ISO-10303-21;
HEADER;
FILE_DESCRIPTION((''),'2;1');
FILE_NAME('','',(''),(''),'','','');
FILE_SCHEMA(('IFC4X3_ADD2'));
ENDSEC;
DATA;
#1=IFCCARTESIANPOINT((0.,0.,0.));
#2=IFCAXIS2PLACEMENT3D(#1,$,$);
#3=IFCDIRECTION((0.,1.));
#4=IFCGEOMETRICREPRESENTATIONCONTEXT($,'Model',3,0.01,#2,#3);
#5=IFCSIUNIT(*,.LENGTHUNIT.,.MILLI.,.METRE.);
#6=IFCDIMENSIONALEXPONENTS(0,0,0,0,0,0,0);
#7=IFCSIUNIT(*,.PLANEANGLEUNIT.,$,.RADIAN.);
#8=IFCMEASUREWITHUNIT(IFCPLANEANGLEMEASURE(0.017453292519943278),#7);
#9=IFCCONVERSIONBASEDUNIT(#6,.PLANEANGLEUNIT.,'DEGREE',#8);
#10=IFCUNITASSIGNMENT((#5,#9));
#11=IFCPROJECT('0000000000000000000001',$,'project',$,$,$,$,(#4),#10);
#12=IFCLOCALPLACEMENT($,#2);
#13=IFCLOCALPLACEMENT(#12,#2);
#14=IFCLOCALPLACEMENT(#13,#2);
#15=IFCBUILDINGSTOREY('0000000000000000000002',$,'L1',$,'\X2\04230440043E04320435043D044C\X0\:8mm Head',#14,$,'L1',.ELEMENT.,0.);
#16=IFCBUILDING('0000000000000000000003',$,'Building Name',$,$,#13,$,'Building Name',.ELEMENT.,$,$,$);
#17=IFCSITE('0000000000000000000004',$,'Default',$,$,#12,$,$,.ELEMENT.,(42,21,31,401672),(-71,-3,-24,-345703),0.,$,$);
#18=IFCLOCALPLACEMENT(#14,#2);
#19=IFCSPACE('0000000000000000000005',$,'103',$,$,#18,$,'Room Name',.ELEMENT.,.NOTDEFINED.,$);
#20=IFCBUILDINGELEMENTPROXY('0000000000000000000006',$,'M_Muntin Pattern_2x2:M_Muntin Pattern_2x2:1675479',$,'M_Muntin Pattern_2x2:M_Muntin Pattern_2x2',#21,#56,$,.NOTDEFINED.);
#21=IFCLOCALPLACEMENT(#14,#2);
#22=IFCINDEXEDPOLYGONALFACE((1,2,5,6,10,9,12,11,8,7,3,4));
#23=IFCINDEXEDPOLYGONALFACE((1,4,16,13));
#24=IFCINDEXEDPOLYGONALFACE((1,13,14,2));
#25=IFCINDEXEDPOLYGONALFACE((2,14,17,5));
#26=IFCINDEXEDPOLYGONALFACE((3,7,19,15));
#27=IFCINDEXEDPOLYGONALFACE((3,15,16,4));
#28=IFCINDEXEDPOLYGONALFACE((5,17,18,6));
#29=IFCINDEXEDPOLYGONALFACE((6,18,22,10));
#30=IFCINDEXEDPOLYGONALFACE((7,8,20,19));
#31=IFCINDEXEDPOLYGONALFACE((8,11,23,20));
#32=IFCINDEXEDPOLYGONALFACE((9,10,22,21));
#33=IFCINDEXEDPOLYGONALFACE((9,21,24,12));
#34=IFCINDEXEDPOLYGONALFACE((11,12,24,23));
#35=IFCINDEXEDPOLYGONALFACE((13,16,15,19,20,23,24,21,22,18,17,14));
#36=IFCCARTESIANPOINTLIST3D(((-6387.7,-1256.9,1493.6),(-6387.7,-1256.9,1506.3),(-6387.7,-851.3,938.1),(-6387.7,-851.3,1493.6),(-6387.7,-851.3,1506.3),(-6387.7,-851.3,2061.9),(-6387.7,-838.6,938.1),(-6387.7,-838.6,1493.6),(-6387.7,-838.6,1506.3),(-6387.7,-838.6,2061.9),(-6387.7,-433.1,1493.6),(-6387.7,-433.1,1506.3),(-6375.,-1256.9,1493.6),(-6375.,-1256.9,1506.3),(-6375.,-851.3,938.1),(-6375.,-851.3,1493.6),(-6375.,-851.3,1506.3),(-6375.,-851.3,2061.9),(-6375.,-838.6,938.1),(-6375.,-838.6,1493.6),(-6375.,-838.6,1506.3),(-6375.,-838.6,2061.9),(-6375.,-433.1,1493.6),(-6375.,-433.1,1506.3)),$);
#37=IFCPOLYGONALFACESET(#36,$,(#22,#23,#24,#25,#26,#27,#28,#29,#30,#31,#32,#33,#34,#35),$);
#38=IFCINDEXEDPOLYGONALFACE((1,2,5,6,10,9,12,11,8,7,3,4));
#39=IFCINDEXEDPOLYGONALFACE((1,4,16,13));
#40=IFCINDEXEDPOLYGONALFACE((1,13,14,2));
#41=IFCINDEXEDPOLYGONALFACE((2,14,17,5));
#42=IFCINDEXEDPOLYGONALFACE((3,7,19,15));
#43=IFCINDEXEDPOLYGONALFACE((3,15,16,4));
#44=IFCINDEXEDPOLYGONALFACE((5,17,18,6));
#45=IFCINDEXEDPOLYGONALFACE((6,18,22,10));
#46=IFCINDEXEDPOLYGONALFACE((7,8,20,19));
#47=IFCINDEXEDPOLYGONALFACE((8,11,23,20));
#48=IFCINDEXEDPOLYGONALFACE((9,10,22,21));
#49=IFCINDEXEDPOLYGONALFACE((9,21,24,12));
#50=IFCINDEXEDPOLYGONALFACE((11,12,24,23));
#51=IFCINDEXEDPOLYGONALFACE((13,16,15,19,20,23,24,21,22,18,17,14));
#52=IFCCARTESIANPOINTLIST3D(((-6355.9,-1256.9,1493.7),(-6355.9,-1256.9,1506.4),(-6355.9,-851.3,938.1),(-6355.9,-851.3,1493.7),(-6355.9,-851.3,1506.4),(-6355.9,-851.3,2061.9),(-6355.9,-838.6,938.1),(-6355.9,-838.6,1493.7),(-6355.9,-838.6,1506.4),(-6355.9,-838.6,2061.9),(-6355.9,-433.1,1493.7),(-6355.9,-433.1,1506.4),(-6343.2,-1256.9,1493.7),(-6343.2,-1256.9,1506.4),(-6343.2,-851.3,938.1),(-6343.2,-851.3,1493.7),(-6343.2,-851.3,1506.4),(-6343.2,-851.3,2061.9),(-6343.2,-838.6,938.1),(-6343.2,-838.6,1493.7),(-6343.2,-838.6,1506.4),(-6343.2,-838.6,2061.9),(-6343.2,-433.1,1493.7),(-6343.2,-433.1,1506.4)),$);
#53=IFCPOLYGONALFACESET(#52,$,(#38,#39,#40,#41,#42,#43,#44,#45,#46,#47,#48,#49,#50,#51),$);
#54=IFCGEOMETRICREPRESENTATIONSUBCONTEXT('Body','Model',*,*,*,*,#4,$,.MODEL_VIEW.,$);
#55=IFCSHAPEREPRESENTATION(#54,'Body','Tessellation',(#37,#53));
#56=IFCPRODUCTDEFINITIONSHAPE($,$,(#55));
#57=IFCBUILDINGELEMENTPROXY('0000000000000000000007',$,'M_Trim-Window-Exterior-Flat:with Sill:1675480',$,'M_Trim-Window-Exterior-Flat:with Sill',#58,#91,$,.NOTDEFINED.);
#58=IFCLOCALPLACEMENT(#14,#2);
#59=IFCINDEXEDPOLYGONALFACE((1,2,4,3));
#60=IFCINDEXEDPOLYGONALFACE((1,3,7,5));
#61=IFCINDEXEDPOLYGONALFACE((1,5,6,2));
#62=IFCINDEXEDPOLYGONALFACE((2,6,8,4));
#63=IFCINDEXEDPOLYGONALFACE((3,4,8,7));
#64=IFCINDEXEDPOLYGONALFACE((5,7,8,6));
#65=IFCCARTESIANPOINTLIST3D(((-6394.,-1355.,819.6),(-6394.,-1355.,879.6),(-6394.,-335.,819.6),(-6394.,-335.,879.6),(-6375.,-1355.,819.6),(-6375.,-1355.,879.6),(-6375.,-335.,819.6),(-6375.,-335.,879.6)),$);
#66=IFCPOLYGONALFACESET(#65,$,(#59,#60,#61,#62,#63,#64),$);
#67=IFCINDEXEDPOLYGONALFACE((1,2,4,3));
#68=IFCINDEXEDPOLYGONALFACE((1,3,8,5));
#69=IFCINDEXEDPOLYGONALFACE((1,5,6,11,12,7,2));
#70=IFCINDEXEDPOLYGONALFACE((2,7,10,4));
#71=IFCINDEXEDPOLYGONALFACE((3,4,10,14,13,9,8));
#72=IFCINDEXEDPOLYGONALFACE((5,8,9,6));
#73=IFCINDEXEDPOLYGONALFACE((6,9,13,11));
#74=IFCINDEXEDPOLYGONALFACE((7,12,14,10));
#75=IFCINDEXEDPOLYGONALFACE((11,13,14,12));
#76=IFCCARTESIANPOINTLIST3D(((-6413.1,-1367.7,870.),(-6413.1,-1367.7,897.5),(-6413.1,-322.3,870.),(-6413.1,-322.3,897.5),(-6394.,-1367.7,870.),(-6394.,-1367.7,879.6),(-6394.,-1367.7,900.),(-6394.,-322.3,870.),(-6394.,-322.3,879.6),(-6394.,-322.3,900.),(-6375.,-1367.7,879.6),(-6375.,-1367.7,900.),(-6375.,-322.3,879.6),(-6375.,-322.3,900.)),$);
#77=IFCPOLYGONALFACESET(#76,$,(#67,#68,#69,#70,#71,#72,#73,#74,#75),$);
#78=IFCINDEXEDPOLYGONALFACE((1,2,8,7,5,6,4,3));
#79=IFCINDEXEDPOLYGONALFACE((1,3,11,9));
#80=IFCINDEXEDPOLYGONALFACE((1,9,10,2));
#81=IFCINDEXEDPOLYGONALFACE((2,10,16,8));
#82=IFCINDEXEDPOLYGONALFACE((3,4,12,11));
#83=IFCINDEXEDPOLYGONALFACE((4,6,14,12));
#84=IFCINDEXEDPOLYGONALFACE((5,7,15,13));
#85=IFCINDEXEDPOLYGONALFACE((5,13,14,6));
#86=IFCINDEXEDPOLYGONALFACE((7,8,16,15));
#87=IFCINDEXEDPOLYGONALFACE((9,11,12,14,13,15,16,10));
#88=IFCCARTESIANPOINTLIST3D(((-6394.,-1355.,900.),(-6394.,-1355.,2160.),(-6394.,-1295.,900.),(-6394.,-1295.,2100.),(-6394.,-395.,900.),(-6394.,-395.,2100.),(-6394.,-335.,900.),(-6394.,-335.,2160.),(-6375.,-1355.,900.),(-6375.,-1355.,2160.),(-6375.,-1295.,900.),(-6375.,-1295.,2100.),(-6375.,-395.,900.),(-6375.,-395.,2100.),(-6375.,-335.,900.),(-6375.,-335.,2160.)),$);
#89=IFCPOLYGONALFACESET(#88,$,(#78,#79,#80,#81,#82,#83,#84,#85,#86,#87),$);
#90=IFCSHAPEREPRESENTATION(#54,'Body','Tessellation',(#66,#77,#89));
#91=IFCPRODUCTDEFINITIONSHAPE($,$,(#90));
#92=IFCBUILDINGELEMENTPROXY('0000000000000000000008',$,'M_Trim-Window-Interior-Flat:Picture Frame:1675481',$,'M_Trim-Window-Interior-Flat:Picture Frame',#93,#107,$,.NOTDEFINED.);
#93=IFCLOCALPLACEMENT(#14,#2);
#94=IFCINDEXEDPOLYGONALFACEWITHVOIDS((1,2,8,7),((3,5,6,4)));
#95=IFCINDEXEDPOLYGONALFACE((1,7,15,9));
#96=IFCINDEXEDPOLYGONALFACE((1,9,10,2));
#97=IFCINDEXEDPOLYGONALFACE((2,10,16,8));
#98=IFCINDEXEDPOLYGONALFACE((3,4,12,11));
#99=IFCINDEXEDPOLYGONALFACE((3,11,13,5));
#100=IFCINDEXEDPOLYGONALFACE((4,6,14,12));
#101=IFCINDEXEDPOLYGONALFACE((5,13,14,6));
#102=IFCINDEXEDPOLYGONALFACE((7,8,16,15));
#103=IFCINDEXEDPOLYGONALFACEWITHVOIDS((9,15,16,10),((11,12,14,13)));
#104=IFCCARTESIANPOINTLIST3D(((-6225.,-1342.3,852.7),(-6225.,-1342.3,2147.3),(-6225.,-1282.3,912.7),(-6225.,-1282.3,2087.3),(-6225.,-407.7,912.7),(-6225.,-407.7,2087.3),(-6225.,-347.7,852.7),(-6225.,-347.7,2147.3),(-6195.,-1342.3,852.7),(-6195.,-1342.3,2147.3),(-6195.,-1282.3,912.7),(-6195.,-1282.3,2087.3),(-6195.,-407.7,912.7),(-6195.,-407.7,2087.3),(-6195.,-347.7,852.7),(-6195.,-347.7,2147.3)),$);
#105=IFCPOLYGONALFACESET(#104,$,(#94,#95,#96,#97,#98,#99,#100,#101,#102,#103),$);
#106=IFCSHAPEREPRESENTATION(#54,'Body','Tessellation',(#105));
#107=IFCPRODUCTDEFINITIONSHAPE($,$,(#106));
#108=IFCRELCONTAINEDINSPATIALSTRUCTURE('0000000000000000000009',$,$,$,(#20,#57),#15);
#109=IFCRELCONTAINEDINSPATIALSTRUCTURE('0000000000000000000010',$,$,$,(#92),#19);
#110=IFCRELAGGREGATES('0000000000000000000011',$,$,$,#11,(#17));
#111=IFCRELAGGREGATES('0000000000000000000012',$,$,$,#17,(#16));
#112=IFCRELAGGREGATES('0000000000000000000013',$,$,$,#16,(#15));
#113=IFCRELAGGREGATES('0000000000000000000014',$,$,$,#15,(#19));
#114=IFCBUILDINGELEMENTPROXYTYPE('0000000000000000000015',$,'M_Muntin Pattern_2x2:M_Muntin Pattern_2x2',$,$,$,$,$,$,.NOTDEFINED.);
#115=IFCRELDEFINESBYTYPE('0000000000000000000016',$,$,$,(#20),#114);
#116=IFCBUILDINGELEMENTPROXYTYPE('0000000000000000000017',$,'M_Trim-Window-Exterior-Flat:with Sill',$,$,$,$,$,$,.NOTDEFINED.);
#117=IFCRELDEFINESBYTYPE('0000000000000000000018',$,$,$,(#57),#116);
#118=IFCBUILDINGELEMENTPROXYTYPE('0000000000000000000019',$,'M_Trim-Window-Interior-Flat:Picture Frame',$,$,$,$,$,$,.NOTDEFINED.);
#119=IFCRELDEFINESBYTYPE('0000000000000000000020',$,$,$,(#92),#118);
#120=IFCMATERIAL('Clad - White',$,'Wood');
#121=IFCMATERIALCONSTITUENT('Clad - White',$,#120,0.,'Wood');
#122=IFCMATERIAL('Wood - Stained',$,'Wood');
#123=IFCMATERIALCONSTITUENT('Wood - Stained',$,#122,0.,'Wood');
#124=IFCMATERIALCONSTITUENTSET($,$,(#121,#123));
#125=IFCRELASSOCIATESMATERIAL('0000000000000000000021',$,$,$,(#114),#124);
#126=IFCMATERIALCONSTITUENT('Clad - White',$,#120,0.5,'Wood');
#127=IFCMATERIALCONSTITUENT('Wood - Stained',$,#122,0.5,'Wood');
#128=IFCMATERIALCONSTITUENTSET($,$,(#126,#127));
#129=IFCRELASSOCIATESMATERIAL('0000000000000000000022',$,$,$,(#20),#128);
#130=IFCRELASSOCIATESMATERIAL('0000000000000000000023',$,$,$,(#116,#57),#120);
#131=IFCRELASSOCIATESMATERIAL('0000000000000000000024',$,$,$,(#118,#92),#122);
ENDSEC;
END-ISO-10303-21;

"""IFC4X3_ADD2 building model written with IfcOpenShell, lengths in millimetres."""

from ifc_helpers import new_model, entity, si_unit, converted_unit, direction, frame, frame_2d, origin, place, context, subcontext, project, spatial, polyline, rectangle, outline, extrude, source, transform, mapped, material, constituent, constituent_set, type_object, type_shapes, element, save


model = new_model("IFC4X3_ADD2")

# Units and contexts
model_context = context("Model", 3, precision=0.01, world=origin(), true_north=direction((0.0, 1.0)))
body_context = subcontext(model_context, "Body", "Model", "MODEL_VIEW")
ifc_project = project(units=[si_unit("LENGTHUNIT", "METRE", prefix="MILLI"), converted_unit("PLANEANGLEUNIT", "DEGREE", entity("IfcPlaneAngleMeasure", 0.017453292519943278), si_unit("PLANEANGLEUNIT", "RADIAN"), dimensions=[0, 0, 0, 0, 0, 0, 0])], contexts=[model_context])

# Site, building, storey
site_placement = place(None, origin())
site = spatial("IfcSite", under=ifc_project, at=site_placement, Name="Default", CompositionType="ELEMENT", RefLatitude=(42, 21, 31, 401672), RefLongitude=(-71, -3, -24, -345703), RefElevation=0.0)
building_placement = place(site_placement, origin())
building = spatial("IfcBuilding", under=site, at=building_placement, Name="Building Name", LongName="Building Name", CompositionType="ELEMENT")
storey_placement = place(building_placement, origin())
storey = spatial("IfcBuildingStorey", under=building, at=storey_placement, Name="L1", ObjectType="Уровень:8mm Head", LongName="L1", CompositionType="ELEMENT", Elevation=0.0)

# Building element proxies
ifc_material_1 = material(Name="Clad - White", Category="Wood")
ifc_constituent_1 = constituent(ifc_material_1, Name="Clad - White", Category="Wood", fraction=0.5)
ifc_material_2 = material(Name="Wood - Stained", Category="Wood")
ifc_constituent_2 = constituent(ifc_material_2, Name="Wood - Stained", Category="Wood", fraction=0.5)
ifc_constituent_set_1 = constituent_set(constituents=[ifc_constituent_1, ifc_constituent_2])
ifc_constituent_3 = constituent(ifc_material_1, Name="Clad - White", Category="Wood", fraction=0.0)
ifc_constituent_4 = constituent(ifc_material_2, Name="Wood - Stained", Category="Wood", fraction=0.0)
ifc_constituent_set_2 = constituent_set(constituents=[ifc_constituent_3, ifc_constituent_4])
building_element_proxy_type_1 = type_object("IfcBuildingElementProxyType", Name="M_Muntin Pattern_2x2:M_Muntin Pattern_2x2", PredefinedType="NOTDEFINED", material=ifc_constituent_set_2)
shared_shape_1 = source(origin(), body_context, "Body", "SweptSolid", [
    extrude(outline(polyline([(6.4, -6.4), (561.9, -6.4), (561.9, 6.3), (6.4, 6.3), (6.4, 411.9), (-6.3, 411.9), (-6.3, 6.3), (-561.9, 6.3), (-561.9, -6.4), (-6.3, -6.4), (-6.3, -411.9), (6.4, -411.9), (6.4, -6.4)])), frame((0.0, -22.2, 561.9), z_axis=(0.0, 1.0, 0.0), x_axis=(0.0, 0.0, 1.0)), (0.0, 0.0, 1.0), 12.7),
    extrude(outline(polyline([(6.4, -6.4), (561.9, -6.4), (561.9, 6.3), (6.4, 6.3), (6.4, 411.9), (-6.3, 411.9), (-6.3, 6.3), (-561.9, 6.3), (-561.9, -6.4), (-6.3, -6.4), (-6.3, -411.9), (6.4, -411.9), (6.4, -6.4)])), frame((0.0, 9.5, 561.9), z_axis=(0.0, 1.0, 0.0), x_axis=(0.0, 0.0, 1.0)), (0.0, 0.0, 1.0), 12.7),
])
type_shapes(building_element_proxy_type_1, [shared_shape_1])
proxy_1_placement = place(storey_placement, frame((-6365.5, -845.0, 938.1), z_axis=(0.0, 0.0, 1.0), x_axis=(0.0, -1.0, 0.0)))
element("IfcBuildingElementProxy", 1, at=proxy_1_placement, inside=storey, type_object=building_element_proxy_type_1, material=ifc_constituent_set_1, Name="M_Muntin Pattern_2x2:M_Muntin Pattern_2x2:1675479", ObjectType="M_Muntin Pattern_2x2:M_Muntin Pattern_2x2", PredefinedType="NOTDEFINED", context=body_context, shape_type="MappedRepresentation", body=[
    mapped(shared_shape_1, transform((0.0, 0.0, 0.0), scale=1.0)),
])
building_element_proxy_type_2 = type_object("IfcBuildingElementProxyType", Name="M_Trim-Window-Exterior-Flat:with Sill", PredefinedType="NOTDEFINED", material=ifc_material_1)
shared_shape_2 = source(origin(), body_context, "Body", "SweptSolid", [
    extrude(rectangle(XDim=1020.0, YDim=60.0, at=frame_2d((0.0, 0.0), x_axis=(1.0, 0.0))), frame((0.0, -1250.4, 0.0), z_axis=(0.0, 0.0, 1.0), x_axis=(-1.0, 0.0, 0.0)), (0.0, 0.0, 1.0), 19.0),
    extrude(outline(polyline([(-19.0, -15.2), (0.0, -15.2), (0.0, -5.7), (19.0, -5.7), (19.0, 14.8), (0.0, 14.8), (-19.0, 12.3), (-19.0, -15.2)])), frame((-522.7, -1214.8, 19.0), z_axis=(1.0, 0.0, 0.0), x_axis=(0.0, 0.0, -1.0)), (0.0, 0.0, 1.0), 1045.4),
    extrude(outline(polyline([(-645.0, -510.0), (615.0, -510.0), (615.0, -450.0), (-585.0, -450.0), (-585.0, 450.0), (615.0, 450.0), (615.0, 510.0), (-645.0, 510.0), (-645.0, -510.0)])), frame((0.0, -585.0, 0.0), z_axis=(0.0, 0.0, 1.0), x_axis=(0.0, -1.0, 0.0)), (0.0, 0.0, 1.0), 19.0),
])
type_shapes(building_element_proxy_type_2, [shared_shape_2])
proxy_2_placement = place(storey_placement, frame((-6375.0, -845.0, 2100.0), z_axis=(-1.0, 0.0, 0.0), x_axis=(0.0, -1.0, 0.0)))
element("IfcBuildingElementProxy", 2, at=proxy_2_placement, inside=storey, type_object=building_element_proxy_type_2, material=ifc_material_1, Name="M_Trim-Window-Exterior-Flat:with Sill:1675480", ObjectType="M_Trim-Window-Exterior-Flat:with Sill", PredefinedType="NOTDEFINED", context=body_context, shape_type="MappedRepresentation", body=[
    mapped(shared_shape_2, transform((0.0, 0.0, 0.0), scale=1.0)),
])

# Shared definitions
space_placement = place(storey_placement, origin())
space = spatial("IfcSpace", under=storey, at=space_placement, Name="103", LongName="Room Name", CompositionType="ELEMENT", PredefinedType="NOTDEFINED")

# Building element proxy
building_element_proxy_type_3 = type_object("IfcBuildingElementProxyType", Name="M_Trim-Window-Interior-Flat:Picture Frame", PredefinedType="NOTDEFINED", material=ifc_material_2)
shared_shape_3 = source(origin(), body_context, "Body", "SweptSolid", [
    extrude(outline(polyline([(-497.3, -647.3), (497.3, -647.3), (497.3, 647.3), (-497.3, 647.3), (-497.3, -647.3)]), holes=[polyline([(-437.3, -587.3), (-437.3, 587.3), (437.3, 587.3), (437.3, -587.3), (-437.3, -587.3)])]), frame((0.0, -600.0, 0.0), z_axis=(0.0, 0.0, 1.0), x_axis=(-1.0, 0.0, 0.0)), (0.0, 0.0, 1.0), 30.0),
])
type_shapes(building_element_proxy_type_3, [shared_shape_3])
proxy_3_placement = place(space_placement, frame((-6225.0, -845.0, 2100.0), z_axis=(1.0, 0.0, 0.0), x_axis=(0.0, 1.0, 0.0)))
element("IfcBuildingElementProxy", 3, at=proxy_3_placement, inside=space, type_object=building_element_proxy_type_3, material=ifc_material_2, Name="M_Trim-Window-Interior-Flat:Picture Frame:1675481", ObjectType="M_Trim-Window-Interior-Flat:Picture Frame", PredefinedType="NOTDEFINED", context=body_context, shape_type="MappedRepresentation", body=[
    mapped(shared_shape_3, transform((0.0, 0.0, 0.0), scale=1.0)),
])

save(model, "model.ifc")
